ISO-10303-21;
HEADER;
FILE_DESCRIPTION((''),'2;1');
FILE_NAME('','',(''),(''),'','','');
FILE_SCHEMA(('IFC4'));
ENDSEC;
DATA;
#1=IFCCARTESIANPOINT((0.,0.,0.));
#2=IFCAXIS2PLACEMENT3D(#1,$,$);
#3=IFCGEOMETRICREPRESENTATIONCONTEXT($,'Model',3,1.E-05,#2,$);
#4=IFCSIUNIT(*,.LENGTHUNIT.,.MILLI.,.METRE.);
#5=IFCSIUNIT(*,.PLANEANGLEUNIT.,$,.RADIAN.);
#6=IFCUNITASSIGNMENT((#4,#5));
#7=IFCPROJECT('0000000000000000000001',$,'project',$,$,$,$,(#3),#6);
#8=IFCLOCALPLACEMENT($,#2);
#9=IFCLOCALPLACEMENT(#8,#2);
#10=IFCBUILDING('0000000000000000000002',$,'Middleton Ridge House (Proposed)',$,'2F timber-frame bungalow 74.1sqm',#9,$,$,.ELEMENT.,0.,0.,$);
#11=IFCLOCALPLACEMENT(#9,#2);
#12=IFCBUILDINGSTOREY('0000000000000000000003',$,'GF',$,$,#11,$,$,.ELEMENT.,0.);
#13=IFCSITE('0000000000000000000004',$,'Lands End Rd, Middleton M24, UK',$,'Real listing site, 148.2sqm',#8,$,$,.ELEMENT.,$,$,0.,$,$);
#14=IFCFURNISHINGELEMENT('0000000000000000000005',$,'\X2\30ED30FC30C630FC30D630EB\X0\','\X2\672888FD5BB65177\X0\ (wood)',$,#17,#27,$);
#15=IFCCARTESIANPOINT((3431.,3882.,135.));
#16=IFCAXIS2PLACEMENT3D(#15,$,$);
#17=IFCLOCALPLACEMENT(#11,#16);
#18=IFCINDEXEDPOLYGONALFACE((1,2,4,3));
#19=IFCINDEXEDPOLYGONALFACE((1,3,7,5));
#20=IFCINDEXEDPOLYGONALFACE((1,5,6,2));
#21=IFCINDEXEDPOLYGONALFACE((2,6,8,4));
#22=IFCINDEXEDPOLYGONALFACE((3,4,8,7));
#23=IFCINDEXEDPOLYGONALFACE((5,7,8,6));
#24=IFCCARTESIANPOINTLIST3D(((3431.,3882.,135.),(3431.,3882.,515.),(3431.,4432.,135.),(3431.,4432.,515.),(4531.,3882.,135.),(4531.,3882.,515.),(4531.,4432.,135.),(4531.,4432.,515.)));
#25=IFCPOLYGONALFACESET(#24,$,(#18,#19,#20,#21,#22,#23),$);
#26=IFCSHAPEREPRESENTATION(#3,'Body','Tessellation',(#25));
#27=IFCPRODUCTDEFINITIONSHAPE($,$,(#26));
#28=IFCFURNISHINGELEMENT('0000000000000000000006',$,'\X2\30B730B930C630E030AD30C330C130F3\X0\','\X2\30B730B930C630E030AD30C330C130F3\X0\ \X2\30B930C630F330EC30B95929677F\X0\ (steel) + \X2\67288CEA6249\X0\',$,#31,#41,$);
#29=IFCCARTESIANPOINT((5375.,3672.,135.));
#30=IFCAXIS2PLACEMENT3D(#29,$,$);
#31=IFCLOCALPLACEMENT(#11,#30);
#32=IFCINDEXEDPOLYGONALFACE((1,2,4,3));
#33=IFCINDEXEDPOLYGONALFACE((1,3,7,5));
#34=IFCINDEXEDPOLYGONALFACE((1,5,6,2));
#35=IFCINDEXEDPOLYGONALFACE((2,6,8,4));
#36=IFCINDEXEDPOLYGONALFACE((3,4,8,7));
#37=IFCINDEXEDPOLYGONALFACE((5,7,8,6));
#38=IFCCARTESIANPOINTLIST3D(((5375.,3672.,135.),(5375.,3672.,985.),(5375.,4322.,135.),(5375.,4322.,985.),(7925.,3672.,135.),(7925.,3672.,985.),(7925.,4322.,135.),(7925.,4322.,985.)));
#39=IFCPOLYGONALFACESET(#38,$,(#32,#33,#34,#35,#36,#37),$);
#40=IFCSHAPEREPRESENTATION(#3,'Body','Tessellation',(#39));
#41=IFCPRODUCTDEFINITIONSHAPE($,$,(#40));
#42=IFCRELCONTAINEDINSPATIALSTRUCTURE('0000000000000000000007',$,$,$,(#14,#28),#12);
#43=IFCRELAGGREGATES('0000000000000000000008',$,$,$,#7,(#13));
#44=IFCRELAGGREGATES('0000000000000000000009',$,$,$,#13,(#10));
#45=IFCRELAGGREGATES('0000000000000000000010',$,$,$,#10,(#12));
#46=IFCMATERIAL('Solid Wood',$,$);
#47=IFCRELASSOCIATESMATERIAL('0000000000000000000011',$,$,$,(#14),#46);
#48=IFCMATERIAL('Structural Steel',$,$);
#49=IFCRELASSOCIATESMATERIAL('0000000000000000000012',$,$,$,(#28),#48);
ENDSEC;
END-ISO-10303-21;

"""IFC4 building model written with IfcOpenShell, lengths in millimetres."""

from ifc_helpers import new_model, si_unit, frame, frame_2d, origin, place, context, project, spatial, rectangle, extrude, material, element, save


model = new_model("IFC4")

# Units and contexts
model_context = context("Model", 3, precision=1e-05, world=origin())
ifc_project = project(units=[si_unit("LENGTHUNIT", "METRE", prefix="MILLI"), si_unit("PLANEANGLEUNIT", "RADIAN")], contexts=[model_context])

# Site, building, storey
site_placement = place(None, origin())
site = spatial("IfcSite", under=ifc_project, at=site_placement, Name="Lands End Rd, Middleton M24, UK", ObjectType="Real listing site, 148.2sqm", CompositionType="ELEMENT", RefElevation=0.0)
building_placement = place(site_placement, origin())
building = spatial("IfcBuilding", under=site, at=building_placement, Name="Middleton Ridge House (Proposed)", ObjectType="2F timber-frame bungalow 74.1sqm", CompositionType="ELEMENT", ElevationOfRefHeight=0.0, ElevationOfTerrain=0.0)
storey_placement = place(building_placement, origin())
storey = spatial("IfcBuildingStorey", under=building, at=storey_placement, Name="GF", CompositionType="ELEMENT", Elevation=0.0)

# Shared definitions
ifc_material_1 = material(Name="Solid Wood")

# Furnishing elements
furnishing_1_placement = place(storey_placement, frame((3431.0, 3882.0, 135.0)))
element("IfcFurnishingElement", 1, at=furnishing_1_placement, inside=storey, material=ifc_material_1, Name="ローテーブル", Description="木製家具 (wood)", context=model_context, shape_type="SweptSolid", body=[
    extrude(rectangle(XDim=1100.0, YDim=550.0, at=frame_2d((550.0, 275.0))), frame((3431.0, 3882.0, 135.0)), (0.0, 0.0, 1.0), 380.0),
])
ifc_material_2 = material(Name="Structural Steel")
furnishing_2_placement = place(storey_placement, frame((5375.0, 3672.0, 135.0)))
element("IfcFurnishingElement", 2, at=furnishing_2_placement, inside=storey, material=ifc_material_2, Name="システムキッチン", Description="システムキッチン ステンレス天板 (steel) + 木質扉", context=model_context, shape_type="SweptSolid", body=[
    extrude(rectangle(XDim=2550.0, YDim=650.0, at=frame_2d((1275.0, 325.0))), frame((5375.0, 3672.0, 135.0)), (0.0, 0.0, 1.0), 850.0),
])

save(model, "model.ifc")
